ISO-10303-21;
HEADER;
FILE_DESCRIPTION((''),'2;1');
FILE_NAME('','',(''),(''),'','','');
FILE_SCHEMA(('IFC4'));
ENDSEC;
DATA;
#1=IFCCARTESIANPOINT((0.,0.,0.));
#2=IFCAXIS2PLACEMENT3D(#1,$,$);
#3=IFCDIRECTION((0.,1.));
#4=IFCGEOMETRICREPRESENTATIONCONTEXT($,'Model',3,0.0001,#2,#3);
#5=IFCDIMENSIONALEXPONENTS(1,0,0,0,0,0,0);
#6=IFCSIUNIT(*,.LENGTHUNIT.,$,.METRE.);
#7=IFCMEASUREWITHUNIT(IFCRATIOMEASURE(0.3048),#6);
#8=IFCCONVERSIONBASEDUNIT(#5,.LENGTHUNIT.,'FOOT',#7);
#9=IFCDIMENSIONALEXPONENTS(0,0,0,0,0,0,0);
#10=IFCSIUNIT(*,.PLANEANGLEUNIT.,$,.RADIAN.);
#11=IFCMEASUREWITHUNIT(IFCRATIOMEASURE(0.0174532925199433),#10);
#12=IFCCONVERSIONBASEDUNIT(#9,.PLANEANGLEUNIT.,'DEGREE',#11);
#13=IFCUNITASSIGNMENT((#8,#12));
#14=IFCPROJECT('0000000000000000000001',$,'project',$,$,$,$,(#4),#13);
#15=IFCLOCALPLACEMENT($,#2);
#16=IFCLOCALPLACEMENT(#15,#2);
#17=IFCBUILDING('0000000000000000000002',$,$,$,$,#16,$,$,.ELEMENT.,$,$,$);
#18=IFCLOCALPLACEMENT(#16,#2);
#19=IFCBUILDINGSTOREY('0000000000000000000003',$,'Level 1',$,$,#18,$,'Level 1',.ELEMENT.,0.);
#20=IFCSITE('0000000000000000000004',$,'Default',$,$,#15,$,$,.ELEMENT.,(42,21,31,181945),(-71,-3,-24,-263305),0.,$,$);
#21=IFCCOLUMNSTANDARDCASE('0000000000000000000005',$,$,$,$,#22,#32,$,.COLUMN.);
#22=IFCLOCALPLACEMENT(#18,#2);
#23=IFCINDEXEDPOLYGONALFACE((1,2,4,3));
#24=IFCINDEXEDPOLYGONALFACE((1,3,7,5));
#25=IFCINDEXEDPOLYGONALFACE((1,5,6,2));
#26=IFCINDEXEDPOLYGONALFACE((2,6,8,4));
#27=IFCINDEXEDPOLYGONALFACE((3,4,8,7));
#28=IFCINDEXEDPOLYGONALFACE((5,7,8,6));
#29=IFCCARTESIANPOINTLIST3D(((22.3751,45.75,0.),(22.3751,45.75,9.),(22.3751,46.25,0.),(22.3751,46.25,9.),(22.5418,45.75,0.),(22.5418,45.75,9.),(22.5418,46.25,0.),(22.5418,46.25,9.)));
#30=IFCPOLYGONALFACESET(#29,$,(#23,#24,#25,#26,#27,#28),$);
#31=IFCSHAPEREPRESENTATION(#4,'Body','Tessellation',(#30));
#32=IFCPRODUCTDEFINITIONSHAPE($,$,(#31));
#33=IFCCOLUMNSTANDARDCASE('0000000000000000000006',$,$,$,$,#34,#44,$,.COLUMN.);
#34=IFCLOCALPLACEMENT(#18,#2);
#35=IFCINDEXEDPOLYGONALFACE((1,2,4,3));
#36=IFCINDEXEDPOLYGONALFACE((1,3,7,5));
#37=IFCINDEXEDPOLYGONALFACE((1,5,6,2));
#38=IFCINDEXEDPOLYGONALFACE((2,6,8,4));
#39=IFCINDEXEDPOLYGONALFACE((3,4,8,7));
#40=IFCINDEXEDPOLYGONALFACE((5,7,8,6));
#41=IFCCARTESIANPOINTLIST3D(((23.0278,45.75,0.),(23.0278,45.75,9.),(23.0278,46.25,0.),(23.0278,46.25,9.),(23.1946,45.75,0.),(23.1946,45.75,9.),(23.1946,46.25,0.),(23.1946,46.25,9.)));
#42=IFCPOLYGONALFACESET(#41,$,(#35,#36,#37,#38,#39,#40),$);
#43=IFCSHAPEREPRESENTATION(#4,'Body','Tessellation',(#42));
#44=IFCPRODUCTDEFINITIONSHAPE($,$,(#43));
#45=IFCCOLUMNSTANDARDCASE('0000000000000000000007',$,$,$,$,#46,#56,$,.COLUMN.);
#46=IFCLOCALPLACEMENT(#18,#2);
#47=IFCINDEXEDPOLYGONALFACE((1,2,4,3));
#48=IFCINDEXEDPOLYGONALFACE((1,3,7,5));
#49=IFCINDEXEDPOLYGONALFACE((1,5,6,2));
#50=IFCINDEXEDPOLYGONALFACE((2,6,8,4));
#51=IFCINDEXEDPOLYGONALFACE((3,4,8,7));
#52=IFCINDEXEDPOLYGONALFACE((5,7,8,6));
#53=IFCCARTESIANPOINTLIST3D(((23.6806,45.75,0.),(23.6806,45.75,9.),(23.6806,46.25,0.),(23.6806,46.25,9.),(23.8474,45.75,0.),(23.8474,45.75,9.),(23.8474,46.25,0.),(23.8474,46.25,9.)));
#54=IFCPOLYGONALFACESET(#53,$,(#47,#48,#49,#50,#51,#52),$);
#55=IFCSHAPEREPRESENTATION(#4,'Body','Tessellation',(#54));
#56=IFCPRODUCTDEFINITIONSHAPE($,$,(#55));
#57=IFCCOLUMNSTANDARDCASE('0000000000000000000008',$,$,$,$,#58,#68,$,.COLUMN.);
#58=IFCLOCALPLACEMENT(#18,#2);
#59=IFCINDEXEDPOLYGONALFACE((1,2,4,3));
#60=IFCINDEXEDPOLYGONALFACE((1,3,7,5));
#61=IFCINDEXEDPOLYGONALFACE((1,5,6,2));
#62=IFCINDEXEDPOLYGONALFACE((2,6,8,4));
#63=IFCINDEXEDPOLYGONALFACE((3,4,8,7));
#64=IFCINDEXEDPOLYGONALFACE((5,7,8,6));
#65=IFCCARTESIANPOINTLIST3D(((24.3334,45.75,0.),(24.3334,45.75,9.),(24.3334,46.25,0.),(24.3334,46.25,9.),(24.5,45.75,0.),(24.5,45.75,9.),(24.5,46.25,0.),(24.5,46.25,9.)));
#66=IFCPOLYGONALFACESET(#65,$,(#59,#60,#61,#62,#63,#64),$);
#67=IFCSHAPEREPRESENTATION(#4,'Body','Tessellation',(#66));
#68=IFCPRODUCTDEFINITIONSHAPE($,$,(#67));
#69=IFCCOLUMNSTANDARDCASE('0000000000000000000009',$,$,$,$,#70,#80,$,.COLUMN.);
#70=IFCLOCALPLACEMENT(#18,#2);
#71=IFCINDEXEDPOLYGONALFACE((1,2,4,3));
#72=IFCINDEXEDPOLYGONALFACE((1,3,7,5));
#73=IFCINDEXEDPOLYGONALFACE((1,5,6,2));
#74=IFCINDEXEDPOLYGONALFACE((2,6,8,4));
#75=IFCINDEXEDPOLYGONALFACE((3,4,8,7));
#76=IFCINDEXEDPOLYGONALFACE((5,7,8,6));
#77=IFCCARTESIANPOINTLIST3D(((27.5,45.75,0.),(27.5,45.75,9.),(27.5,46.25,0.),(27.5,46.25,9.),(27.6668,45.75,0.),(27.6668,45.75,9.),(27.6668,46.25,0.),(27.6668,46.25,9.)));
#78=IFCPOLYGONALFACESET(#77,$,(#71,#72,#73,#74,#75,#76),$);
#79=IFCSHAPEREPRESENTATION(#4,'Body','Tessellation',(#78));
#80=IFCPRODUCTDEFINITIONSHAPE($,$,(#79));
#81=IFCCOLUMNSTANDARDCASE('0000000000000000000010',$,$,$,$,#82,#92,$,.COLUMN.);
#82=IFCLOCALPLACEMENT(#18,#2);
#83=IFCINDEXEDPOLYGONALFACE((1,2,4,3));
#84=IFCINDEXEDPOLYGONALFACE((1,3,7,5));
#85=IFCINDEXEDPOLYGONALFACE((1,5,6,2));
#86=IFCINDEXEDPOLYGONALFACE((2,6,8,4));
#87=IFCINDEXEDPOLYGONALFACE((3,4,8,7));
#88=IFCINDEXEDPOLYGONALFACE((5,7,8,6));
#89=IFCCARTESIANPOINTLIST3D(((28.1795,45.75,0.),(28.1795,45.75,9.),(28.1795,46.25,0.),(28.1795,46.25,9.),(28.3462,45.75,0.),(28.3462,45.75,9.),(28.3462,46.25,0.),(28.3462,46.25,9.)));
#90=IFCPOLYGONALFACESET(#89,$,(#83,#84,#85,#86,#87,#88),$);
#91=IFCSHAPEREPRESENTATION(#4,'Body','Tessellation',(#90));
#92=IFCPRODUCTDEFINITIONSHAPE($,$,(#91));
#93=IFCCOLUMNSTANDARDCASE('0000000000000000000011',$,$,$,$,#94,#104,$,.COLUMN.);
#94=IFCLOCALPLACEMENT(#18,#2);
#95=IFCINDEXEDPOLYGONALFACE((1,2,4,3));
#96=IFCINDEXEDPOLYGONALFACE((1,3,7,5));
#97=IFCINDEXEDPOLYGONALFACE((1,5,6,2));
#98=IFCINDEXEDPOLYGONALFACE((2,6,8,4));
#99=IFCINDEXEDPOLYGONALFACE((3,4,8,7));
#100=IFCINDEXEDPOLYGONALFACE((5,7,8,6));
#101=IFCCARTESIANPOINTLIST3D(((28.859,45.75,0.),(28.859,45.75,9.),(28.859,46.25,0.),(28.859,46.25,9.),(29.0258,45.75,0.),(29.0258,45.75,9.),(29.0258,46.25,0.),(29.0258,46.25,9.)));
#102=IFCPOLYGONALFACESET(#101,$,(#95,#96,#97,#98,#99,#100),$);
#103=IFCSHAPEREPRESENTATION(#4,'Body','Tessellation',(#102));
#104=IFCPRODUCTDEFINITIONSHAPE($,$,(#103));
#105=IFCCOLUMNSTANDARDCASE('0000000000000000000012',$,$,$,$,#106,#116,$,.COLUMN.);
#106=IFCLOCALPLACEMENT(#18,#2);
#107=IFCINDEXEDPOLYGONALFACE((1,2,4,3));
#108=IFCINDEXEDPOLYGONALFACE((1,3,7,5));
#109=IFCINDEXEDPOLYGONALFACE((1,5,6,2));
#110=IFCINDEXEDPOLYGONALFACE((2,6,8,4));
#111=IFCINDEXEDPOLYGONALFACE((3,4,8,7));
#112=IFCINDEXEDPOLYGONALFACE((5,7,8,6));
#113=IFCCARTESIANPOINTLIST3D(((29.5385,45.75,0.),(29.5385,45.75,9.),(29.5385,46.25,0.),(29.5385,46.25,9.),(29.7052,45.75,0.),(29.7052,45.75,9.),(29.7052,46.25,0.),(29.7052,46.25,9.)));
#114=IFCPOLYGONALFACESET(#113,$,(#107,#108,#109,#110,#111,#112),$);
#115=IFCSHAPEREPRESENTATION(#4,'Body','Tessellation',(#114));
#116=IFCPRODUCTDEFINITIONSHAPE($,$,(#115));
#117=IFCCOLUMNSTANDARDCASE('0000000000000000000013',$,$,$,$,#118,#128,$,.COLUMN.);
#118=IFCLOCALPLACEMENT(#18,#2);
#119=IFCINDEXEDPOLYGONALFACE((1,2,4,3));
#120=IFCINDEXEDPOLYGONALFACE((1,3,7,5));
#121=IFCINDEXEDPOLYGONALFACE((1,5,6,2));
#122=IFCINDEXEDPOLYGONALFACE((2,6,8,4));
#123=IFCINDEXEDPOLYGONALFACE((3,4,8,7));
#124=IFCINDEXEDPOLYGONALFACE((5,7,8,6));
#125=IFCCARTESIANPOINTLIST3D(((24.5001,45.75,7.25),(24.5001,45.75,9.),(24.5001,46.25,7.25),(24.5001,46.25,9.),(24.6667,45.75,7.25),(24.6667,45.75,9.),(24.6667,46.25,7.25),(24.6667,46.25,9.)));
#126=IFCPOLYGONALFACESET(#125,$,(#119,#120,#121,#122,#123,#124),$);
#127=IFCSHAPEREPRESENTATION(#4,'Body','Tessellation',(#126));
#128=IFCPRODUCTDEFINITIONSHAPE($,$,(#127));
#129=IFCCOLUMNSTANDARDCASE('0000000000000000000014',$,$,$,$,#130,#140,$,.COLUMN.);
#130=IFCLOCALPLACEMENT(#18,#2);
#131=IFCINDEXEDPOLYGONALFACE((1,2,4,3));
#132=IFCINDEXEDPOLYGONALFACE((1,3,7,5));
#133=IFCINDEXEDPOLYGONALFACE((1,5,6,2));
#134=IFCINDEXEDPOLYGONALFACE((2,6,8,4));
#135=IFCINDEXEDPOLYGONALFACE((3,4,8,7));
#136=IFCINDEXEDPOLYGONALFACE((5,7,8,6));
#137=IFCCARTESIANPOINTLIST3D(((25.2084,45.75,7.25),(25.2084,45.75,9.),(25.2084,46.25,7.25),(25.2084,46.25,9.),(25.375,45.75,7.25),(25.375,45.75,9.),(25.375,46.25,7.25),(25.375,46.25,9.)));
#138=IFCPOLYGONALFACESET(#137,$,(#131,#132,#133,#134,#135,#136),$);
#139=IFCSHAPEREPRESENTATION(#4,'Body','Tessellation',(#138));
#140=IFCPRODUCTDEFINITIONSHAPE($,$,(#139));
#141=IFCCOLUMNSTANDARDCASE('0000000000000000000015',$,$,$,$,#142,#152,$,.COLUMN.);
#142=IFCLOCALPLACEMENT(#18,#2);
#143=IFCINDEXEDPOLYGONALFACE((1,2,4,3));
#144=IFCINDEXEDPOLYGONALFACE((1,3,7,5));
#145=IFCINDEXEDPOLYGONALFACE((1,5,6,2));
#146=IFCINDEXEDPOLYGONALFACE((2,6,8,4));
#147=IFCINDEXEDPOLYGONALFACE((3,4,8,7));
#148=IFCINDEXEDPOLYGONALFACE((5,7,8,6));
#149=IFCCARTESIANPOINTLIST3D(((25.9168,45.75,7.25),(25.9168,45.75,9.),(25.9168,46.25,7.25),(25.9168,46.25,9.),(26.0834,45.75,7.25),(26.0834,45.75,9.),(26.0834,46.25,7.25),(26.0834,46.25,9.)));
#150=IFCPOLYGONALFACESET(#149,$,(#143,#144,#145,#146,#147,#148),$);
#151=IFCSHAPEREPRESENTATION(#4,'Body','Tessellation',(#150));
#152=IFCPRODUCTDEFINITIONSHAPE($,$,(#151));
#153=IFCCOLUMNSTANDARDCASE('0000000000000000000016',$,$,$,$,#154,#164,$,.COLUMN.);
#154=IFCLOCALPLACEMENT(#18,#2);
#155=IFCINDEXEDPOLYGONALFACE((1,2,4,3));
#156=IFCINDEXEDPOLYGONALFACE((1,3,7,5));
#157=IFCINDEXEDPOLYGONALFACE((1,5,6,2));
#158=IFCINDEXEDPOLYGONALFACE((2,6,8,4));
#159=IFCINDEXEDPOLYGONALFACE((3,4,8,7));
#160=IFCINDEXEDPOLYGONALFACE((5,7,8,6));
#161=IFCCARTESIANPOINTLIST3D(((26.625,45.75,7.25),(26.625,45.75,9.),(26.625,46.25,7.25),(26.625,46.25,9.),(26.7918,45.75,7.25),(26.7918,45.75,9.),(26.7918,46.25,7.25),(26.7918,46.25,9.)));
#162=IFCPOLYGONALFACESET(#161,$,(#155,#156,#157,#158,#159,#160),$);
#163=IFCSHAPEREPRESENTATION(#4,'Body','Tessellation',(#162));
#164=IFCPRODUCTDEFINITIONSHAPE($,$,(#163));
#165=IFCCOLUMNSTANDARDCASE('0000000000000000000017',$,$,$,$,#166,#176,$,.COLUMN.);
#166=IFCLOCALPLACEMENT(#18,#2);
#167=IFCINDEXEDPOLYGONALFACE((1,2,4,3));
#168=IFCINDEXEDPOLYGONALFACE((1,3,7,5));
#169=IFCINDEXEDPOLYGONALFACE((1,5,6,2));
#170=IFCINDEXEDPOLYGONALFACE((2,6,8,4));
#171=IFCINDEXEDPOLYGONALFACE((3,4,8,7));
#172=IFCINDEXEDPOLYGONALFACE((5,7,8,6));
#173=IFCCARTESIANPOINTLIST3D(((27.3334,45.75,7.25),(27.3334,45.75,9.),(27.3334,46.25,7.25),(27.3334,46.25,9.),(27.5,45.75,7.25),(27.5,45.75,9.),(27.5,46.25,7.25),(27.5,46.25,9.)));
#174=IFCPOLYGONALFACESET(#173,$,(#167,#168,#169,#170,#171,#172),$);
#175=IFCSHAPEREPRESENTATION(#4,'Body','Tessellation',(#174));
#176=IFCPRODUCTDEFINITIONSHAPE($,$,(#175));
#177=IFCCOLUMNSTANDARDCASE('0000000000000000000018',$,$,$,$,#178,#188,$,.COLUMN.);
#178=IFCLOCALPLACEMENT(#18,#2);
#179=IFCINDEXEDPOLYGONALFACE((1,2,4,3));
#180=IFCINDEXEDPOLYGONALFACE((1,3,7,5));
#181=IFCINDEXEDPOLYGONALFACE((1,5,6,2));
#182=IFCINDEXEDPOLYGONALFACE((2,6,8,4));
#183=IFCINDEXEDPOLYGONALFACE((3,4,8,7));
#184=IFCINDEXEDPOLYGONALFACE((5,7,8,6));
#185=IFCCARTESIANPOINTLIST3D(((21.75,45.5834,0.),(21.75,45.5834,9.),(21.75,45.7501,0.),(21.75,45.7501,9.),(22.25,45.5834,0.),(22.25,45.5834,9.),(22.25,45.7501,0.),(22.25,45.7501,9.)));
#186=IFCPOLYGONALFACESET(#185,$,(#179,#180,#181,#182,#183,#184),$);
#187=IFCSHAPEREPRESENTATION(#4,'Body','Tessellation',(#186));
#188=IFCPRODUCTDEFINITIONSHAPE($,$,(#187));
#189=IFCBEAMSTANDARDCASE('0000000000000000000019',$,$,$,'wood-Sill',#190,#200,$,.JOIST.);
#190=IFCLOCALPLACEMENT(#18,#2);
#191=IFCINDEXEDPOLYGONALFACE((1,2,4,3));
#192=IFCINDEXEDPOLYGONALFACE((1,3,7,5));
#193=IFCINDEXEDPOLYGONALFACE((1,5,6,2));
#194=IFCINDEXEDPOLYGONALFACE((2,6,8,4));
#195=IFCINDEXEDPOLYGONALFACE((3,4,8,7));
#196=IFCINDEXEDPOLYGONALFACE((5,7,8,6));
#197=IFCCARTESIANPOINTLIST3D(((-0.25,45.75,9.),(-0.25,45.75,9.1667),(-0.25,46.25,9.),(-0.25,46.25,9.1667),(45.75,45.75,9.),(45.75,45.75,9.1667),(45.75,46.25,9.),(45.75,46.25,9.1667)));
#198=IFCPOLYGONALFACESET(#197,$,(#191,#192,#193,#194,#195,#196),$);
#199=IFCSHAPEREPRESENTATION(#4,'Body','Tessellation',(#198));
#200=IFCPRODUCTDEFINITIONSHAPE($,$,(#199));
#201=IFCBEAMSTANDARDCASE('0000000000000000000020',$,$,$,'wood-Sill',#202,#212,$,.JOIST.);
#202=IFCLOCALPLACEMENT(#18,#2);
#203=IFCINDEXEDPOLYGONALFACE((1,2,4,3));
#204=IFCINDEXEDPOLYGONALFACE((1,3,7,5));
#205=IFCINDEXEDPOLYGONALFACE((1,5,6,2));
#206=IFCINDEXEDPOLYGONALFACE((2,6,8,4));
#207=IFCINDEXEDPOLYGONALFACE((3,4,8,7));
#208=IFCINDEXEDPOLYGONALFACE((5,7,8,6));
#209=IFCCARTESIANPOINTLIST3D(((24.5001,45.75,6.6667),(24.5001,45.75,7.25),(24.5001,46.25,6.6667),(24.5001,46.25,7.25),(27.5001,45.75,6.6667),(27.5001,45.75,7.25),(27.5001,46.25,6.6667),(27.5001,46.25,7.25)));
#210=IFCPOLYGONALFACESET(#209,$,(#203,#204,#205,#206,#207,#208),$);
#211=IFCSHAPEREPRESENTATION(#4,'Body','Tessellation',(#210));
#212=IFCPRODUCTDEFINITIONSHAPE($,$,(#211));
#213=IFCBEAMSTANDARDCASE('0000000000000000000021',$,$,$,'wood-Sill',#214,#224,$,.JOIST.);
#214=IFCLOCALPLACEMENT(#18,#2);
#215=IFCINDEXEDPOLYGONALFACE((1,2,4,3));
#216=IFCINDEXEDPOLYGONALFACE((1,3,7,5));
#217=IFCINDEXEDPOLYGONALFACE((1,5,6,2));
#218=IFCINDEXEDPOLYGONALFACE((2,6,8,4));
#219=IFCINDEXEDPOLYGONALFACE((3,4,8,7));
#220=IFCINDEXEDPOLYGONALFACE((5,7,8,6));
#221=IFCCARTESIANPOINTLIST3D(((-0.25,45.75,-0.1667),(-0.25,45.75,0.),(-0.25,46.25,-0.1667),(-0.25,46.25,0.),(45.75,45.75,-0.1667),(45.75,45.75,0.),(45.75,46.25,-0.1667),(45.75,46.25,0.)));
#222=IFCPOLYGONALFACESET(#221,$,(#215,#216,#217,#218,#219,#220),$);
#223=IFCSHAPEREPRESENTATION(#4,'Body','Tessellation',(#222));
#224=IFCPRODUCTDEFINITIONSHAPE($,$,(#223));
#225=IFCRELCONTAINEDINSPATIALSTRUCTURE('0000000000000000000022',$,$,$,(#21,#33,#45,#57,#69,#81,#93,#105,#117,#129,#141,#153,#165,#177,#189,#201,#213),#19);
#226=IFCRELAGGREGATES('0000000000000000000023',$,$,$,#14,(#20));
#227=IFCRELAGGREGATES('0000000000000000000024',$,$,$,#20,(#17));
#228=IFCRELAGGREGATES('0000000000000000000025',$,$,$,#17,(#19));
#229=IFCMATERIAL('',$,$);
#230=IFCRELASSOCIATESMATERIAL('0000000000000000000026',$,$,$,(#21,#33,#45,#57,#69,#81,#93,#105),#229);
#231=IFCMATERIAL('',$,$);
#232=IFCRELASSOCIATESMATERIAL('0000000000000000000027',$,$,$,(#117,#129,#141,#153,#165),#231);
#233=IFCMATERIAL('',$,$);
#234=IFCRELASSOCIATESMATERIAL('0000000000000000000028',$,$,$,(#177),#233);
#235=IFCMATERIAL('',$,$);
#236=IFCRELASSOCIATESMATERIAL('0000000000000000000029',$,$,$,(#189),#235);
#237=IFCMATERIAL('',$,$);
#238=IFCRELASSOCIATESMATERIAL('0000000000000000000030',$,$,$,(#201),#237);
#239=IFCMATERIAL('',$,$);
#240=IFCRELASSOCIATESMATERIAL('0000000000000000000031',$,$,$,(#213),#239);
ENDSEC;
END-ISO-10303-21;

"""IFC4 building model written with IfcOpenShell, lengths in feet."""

from ifc_helpers import new_model, entity, si_unit, converted_unit, direction, frame, origin, place, context, project, spatial, rectangle, extrude, material, element, save


model = new_model("IFC4")

# Units and contexts
model_context = context("Model", 3, precision=0.0001, world=origin(), true_north=direction((0.0, 1.0)))
ifc_project = project(units=[converted_unit("LENGTHUNIT", "FOOT", entity("IfcRatioMeasure", 0.3048), si_unit("LENGTHUNIT", "METRE"), dimensions=[1, 0, 0, 0, 0, 0, 0]), converted_unit("PLANEANGLEUNIT", "DEGREE", entity("IfcRatioMeasure", 0.0174532925199433), si_unit("PLANEANGLEUNIT", "RADIAN"), dimensions=[0, 0, 0, 0, 0, 0, 0])], contexts=[model_context])

# Site, building, storey
site_placement = place(None, origin())
site = spatial("IfcSite", under=ifc_project, at=site_placement, Name="Default", CompositionType="ELEMENT", RefLatitude=(42, 21, 31, 181945), RefLongitude=(-71, -3, -24, -263305), RefElevation=0.0)
building_placement = place(site_placement, origin())
building = spatial("IfcBuilding", under=site, at=building_placement, CompositionType="ELEMENT")
storey_placement = place(building_placement, origin())
storey = spatial("IfcBuildingStorey", under=building, at=storey_placement, Name="Level 1", LongName="Level 1", CompositionType="ELEMENT", Elevation=0.0)

# Columns
ifc_material_1 = material(Name="")
placement_1 = place(storey_placement, frame((-0.25, 46.0, 0.0)))
for number, where, z_axis, x_axis in (
    (1, (22.7084, 0.0, 0.0), (0.0, 0.0, 1.0), (1.0, 0.0, 0.0)),
    (2, (23.3612, 0.0, 0.0), (0.0, 0.0, 1.0), (1.0, 0.0, 0.0)),
    (3, (24.014, 0.0, 0.0), (0.0, 0.0, 1.0), (1.0, 0.0, 0.0)),
    (4, (24.6667, 0.0, 0.0), (0.0, 0.0, 1.0), (1.0, 0.0, 0.0)),
    (5, (27.8334, 0.0, 0.0), (0.0, 0.0, 1.0), (1.0, 0.0, 0.0)),
    (6, (28.5129, 0.0, 0.0), (0.0, 0.0, 1.0), (1.0, 0.0, 0.0)),
    (7, (29.1924, 0.0, 0.0), (0.0, 0.0, 1.0), (1.0, 0.0, 0.0)),
    (8, (29.8719, 0.0, 0.0), (0.0, 0.0, 1.0), (1.0, 0.0, 0.0)),
):
    element("IfcColumnStandardCase", number, at=place(placement_1, frame(where, z_axis=z_axis, x_axis=x_axis)), inside=storey, material=ifc_material_1, PredefinedType="COLUMN", context=model_context, shape_type="SweptSolid", body=[
        extrude(rectangle(XDim=0.1667, YDim=0.5), origin(), (0.0, 0.0, 1.0), 9.0),
    ])
ifc_material_2 = material(Name="")
for number, where, z_axis, x_axis in (
    (9, (24.8334, 0.0, 7.25), (0.0, 0.0, 1.0), (1.0, 0.0, 0.0)),
    (10, (25.5417, 0.0, 7.25), (0.0, 0.0, 1.0), (1.0, 0.0, 0.0)),
    (11, (26.2501, 0.0, 7.25), (0.0, 0.0, 1.0), (1.0, 0.0, 0.0)),
    (12, (26.9584, 0.0, 7.25), (0.0, 0.0, 1.0), (1.0, 0.0, 0.0)),
    (13, (27.6667, 0.0, 7.25), (0.0, 0.0, 1.0), (1.0, 0.0, 0.0)),
):
    element("IfcColumnStandardCase", number, at=place(placement_1, frame(where, z_axis=z_axis, x_axis=x_axis)), inside=storey, material=ifc_material_2, PredefinedType="COLUMN", context=model_context, shape_type="SweptSolid", body=[
        extrude(rectangle(XDim=0.1667, YDim=0.5), origin(), (0.0, 0.0, 1.0), 1.75),
    ])
ifc_material_3 = material(Name="")
placement_2 = place(storey_placement, frame((22.0, 45.75, 0.0), z_axis=(0.0, 0.0, 1.0), x_axis=(0.0, -1.0, 0.0)))
for number, where, z_axis, x_axis in (
    (14, (0.0833, 0.0, 0.0), (0.0, 0.0, 1.0), (1.0, 0.0, 0.0)),
):
    element("IfcColumnStandardCase", number, at=place(placement_2, frame(where, z_axis=z_axis, x_axis=x_axis)), inside=storey, material=ifc_material_3, PredefinedType="COLUMN", context=model_context, shape_type="SweptSolid", body=[
        extrude(rectangle(XDim=0.1667, YDim=0.5), origin(), (0.0, 0.0, 1.0), 9.0),
    ])

# Beams
ifc_material_4 = material(Name="")
beam_1_placement = place(placement_1, frame((23.0, 0.0, 9.0), z_axis=(0.0, 0.0, 1.0), x_axis=(1.0, 0.0, 0.0)))
element("IfcBeamStandardCase", 15, at=beam_1_placement, inside=storey, material=ifc_material_4, ObjectType="wood-Sill", PredefinedType="JOIST", context=model_context, shape_type="SweptSolid", body=[
    extrude(rectangle(XDim=46.0, YDim=0.5), origin(), (0.0, 0.0, 1.0), 0.1667),
])
ifc_material_5 = material(Name="")
for number, where, z_axis, x_axis in (
    (16, (26.2501, 0.0, 6.6667), (0.0, 0.0, 1.0), (1.0, 0.0, 0.0)),
):
    element("IfcBeamStandardCase", number, at=place(placement_1, frame(where, z_axis=z_axis, x_axis=x_axis)), inside=storey, material=ifc_material_5, ObjectType="wood-Sill", PredefinedType="JOIST", context=model_context, shape_type="SweptSolid", body=[
        extrude(rectangle(XDim=3.0, YDim=0.5), origin(), (0.0, 0.0, 1.0), 0.5833),
    ])
ifc_material_6 = material(Name="")
beam_2_placement = place(placement_1, frame((23.0, 0.0, -0.1667), z_axis=(0.0, 0.0, 1.0), x_axis=(1.0, 0.0, 0.0)))
element("IfcBeamStandardCase", 17, at=beam_2_placement, inside=storey, material=ifc_material_6, ObjectType="wood-Sill", PredefinedType="JOIST", context=model_context, shape_type="SweptSolid", body=[
    extrude(rectangle(XDim=46.0, YDim=0.5), origin(), (0.0, 0.0, 1.0), 0.1667),
])

save(model, "model.ifc")
